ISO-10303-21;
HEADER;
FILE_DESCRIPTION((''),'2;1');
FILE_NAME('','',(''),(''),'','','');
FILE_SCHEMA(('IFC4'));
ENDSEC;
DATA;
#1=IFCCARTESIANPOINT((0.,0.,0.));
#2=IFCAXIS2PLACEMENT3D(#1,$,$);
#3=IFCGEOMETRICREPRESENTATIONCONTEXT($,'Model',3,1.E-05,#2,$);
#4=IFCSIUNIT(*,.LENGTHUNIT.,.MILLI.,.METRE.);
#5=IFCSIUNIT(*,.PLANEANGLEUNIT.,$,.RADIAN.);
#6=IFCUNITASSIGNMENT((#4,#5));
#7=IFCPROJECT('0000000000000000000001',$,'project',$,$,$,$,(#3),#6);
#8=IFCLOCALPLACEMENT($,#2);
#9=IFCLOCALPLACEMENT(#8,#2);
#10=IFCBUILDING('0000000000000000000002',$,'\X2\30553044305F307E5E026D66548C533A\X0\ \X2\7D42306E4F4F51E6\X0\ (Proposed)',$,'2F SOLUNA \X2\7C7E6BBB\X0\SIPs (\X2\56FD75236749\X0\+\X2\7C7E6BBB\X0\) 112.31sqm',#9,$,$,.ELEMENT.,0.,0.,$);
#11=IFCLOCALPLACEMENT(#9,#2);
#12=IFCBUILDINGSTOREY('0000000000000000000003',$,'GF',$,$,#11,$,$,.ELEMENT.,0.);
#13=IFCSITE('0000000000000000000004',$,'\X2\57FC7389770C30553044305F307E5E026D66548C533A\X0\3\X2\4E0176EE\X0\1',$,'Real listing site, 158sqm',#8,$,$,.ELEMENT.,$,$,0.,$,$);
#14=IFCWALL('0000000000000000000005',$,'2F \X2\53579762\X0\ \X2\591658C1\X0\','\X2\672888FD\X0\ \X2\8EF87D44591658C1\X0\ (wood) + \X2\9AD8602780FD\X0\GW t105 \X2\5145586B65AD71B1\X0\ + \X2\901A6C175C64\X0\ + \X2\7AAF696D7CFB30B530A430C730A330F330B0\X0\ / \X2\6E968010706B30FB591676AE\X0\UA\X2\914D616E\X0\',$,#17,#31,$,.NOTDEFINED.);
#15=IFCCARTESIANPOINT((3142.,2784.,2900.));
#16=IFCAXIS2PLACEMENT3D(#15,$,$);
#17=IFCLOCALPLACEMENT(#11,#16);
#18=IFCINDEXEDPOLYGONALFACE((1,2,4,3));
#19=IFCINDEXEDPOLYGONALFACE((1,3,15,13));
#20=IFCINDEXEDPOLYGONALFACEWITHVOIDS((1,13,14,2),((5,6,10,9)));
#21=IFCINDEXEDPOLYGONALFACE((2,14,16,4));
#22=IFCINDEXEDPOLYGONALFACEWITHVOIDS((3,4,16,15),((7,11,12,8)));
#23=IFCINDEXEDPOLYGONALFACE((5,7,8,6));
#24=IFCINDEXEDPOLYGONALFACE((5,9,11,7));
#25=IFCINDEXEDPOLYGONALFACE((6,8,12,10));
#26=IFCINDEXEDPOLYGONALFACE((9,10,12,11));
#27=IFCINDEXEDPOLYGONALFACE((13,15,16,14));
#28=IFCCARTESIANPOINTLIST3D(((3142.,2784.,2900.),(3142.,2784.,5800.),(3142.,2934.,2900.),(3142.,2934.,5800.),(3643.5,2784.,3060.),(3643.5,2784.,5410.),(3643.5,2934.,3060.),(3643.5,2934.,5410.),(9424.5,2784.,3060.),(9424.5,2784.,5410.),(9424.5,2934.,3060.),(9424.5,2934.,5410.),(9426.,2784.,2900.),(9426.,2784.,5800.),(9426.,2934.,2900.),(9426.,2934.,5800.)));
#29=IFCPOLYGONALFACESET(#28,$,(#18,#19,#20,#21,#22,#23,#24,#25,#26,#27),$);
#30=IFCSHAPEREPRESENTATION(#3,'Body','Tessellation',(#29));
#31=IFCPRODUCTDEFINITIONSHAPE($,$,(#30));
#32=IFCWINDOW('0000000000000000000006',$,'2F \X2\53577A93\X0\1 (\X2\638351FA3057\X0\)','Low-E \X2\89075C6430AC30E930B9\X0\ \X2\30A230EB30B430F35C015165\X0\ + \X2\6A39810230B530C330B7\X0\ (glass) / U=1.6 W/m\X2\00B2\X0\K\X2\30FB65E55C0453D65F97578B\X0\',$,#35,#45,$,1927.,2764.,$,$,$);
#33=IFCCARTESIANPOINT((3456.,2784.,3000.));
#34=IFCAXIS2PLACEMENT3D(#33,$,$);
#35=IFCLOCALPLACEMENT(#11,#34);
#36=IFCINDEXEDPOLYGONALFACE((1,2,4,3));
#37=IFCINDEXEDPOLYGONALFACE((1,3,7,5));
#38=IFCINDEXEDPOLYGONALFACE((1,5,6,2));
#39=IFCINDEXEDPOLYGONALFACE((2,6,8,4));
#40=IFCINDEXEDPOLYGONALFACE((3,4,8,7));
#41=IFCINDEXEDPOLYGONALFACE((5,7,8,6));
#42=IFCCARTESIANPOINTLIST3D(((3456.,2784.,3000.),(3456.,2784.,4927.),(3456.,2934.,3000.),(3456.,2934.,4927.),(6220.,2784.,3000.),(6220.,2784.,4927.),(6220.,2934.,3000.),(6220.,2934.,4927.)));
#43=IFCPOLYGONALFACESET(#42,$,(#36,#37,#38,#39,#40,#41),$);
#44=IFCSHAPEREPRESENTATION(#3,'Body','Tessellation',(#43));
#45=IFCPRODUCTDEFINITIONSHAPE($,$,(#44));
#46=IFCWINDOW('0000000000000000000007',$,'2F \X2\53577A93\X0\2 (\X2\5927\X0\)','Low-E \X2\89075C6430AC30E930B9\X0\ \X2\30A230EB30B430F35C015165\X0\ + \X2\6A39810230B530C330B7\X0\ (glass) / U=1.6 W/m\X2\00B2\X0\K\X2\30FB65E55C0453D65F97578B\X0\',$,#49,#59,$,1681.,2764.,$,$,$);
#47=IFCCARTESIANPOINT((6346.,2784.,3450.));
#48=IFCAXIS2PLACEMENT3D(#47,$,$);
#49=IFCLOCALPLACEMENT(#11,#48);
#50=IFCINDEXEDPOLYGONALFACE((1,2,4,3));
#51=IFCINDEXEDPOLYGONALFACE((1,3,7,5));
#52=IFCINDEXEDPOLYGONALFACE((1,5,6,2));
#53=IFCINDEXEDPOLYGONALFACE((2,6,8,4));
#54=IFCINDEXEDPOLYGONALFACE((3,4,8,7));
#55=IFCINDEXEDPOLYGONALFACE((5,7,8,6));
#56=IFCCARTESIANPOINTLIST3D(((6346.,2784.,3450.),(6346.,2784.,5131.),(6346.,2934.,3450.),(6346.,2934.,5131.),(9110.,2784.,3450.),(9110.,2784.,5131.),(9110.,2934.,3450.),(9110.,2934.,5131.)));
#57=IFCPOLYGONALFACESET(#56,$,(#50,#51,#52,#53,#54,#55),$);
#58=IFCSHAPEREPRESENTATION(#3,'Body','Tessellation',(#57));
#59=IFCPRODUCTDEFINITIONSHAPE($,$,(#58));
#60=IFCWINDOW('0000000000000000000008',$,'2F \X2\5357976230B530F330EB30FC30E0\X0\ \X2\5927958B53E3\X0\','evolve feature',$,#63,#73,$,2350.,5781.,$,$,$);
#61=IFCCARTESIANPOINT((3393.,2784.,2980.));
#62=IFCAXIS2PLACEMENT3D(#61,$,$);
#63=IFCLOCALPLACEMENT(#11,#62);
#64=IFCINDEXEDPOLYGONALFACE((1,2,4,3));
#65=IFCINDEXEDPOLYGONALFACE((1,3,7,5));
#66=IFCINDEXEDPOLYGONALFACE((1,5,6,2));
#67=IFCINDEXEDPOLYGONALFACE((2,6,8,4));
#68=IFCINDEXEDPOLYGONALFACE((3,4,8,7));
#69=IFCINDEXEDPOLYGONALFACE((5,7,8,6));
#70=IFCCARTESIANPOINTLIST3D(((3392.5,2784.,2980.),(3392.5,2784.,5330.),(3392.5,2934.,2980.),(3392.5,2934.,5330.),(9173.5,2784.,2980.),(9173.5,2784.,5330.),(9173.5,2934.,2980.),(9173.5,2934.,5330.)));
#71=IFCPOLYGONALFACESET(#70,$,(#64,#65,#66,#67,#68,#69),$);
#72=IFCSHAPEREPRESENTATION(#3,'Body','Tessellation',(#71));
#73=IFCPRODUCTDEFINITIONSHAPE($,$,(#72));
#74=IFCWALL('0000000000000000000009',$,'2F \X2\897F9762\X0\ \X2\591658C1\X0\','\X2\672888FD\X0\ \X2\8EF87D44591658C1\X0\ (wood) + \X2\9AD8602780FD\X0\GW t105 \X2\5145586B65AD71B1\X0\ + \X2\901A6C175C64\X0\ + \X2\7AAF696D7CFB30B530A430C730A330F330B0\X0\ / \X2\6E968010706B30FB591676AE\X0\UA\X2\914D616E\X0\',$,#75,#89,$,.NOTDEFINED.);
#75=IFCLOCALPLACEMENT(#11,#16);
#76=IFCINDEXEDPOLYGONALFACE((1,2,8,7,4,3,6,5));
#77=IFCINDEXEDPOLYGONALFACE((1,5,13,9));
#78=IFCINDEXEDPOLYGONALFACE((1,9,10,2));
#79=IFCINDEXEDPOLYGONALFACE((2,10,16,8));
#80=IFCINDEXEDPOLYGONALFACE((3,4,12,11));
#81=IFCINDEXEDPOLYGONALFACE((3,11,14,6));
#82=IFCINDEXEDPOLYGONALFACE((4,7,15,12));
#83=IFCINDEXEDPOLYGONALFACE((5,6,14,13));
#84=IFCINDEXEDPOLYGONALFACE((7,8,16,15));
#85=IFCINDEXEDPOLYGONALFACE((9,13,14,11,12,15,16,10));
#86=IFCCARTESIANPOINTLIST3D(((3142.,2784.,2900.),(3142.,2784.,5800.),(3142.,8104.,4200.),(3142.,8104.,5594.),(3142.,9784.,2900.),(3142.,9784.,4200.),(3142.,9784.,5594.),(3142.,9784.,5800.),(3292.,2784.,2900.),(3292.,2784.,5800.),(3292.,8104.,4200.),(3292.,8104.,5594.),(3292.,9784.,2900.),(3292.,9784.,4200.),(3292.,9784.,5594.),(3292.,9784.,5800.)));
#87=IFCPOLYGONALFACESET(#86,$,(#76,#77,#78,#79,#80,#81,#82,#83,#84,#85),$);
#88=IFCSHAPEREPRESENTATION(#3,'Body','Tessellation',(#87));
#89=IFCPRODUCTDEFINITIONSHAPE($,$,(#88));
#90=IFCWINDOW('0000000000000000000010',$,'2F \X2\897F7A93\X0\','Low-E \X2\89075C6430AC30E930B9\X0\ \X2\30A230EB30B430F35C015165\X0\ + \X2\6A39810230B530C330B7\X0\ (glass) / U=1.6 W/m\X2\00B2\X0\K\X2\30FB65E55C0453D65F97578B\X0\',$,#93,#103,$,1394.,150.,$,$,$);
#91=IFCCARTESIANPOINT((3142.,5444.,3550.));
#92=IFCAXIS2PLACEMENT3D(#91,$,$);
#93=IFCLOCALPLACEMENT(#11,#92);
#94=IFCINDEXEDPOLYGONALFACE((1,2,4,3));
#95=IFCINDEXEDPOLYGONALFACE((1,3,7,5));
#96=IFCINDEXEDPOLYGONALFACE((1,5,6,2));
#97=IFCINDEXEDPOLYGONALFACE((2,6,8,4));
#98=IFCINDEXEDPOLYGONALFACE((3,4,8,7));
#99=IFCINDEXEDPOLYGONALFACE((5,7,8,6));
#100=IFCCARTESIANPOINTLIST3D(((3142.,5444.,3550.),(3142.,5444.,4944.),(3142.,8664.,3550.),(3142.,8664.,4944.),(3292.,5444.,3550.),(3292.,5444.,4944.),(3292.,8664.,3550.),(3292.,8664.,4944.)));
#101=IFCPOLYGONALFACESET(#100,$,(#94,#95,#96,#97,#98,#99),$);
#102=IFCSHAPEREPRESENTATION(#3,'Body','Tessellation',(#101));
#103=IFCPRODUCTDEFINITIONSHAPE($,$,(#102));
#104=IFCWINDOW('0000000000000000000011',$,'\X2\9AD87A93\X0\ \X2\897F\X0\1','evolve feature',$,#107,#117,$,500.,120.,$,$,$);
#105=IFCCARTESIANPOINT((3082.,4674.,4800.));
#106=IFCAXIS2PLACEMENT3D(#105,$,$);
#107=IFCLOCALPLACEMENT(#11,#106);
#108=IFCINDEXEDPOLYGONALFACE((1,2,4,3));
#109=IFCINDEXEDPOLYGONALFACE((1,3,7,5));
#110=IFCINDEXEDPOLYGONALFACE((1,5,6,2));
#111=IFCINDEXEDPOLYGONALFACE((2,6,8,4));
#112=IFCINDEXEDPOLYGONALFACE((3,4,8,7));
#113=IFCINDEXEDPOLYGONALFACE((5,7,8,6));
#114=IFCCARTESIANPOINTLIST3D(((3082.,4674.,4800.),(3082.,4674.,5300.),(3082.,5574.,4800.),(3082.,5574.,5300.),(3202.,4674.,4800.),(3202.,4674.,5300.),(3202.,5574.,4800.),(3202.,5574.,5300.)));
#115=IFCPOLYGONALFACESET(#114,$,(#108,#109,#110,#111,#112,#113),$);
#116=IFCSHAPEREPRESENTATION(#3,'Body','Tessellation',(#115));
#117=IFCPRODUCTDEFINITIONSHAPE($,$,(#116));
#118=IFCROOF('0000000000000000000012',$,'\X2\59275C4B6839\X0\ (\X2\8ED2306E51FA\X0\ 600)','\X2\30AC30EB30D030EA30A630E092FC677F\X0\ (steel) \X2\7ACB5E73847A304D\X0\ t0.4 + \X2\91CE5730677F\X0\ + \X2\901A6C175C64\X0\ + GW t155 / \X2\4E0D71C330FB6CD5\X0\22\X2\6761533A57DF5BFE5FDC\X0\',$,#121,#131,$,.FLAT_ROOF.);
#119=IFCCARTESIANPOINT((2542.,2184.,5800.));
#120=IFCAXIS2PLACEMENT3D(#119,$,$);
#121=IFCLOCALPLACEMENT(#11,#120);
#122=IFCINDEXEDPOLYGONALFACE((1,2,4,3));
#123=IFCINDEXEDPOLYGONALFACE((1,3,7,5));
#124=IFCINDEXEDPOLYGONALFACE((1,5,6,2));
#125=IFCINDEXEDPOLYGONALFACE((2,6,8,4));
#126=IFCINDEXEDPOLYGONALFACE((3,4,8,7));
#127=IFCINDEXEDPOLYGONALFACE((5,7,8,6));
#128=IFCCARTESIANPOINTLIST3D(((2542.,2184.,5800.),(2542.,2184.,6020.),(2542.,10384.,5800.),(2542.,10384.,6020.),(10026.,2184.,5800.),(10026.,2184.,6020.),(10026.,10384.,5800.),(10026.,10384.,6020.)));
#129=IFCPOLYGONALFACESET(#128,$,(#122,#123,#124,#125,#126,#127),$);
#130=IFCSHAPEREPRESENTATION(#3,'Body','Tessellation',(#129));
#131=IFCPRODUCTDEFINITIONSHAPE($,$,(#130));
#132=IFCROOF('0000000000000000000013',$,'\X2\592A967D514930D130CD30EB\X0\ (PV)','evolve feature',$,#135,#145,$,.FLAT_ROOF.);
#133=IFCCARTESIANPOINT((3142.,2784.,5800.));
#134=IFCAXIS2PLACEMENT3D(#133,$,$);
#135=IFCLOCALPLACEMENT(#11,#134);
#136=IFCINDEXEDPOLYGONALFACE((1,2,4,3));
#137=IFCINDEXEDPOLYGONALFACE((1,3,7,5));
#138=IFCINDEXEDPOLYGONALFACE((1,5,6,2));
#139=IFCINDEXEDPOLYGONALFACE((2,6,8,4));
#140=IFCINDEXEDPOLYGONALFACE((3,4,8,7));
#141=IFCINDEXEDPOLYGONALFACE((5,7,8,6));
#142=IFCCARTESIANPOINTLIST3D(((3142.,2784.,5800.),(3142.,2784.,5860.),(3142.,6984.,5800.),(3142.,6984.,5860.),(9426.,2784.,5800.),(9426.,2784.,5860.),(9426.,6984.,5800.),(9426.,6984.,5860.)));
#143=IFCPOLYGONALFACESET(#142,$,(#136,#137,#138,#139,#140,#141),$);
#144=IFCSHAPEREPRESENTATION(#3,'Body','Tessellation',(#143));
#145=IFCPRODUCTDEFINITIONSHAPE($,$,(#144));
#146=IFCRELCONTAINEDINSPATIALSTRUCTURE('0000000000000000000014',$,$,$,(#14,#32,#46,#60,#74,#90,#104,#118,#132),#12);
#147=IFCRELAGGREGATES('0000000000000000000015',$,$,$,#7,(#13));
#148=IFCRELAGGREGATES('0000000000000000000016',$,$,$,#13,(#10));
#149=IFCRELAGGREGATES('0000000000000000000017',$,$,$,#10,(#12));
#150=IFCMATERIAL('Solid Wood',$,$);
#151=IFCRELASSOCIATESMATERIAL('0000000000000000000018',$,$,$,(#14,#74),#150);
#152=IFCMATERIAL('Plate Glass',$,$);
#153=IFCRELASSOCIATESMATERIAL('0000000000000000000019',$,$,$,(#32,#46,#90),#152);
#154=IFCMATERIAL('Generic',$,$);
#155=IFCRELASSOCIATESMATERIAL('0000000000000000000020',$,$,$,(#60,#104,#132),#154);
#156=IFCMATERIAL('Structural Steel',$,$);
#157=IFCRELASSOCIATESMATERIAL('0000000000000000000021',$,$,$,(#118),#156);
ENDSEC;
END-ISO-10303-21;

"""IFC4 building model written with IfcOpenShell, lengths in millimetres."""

from ifc_helpers import new_model, si_unit, frame, frame_2d, origin, place, context, project, spatial, rectangle, extrude, material, element, fill, save


model = new_model("IFC4")

# Units and contexts
model_context = context("Model", 3, precision=1e-05, world=origin())
ifc_project = project(units=[si_unit("LENGTHUNIT", "METRE", prefix="MILLI"), si_unit("PLANEANGLEUNIT", "RADIAN")], contexts=[model_context])

# Site, building, storey
site_placement = place(None, origin())
site = spatial("IfcSite", under=ifc_project, at=site_placement, Name="埼玉県さいたま市浦和区3丁目1", ObjectType="Real listing site, 158sqm", CompositionType="ELEMENT", RefElevation=0.0)
building_placement = place(site_placement, origin())
building = spatial("IfcBuilding", under=site, at=building_placement, Name="さいたま市浦和区 終の住処 (Proposed)", ObjectType="2F SOLUNA 籾殻SIPs (国産杉+籾殻) 112.31sqm", CompositionType="ELEMENT", ElevationOfRefHeight=0.0, ElevationOfTerrain=0.0)
storey_placement = place(building_placement, origin())
storey = spatial("IfcBuildingStorey", under=building, at=storey_placement, Name="GF", CompositionType="ELEMENT", Elevation=0.0)

# Shared definitions
ifc_material_1 = material(Name="Solid Wood")
ifc_material_2 = material(Name="Generic")

# Shared definitions
ifc_material_3 = material(Name="Plate Glass")

# Walls, openings, windows
wall_1_placement = place(storey_placement, frame((3142.0, 2784.0, 2900.0)))
wall_1 = element("IfcWall", 1, at=wall_1_placement, inside=storey, material=ifc_material_1, Name="2F 南面 外壁", Description="木製 軸組外壁 (wood) + 高性能GW t105 充填断熱 + 通気層 + 窯業系サイディング / 準耐火・外皮UA配慮", PredefinedType="NOTDEFINED", context=model_context, shape_type="SweptSolid", body=[
    extrude(rectangle(XDim=6284.0, YDim=150.0, at=frame_2d((3142.0, 75.0))), frame((3142.0, 2784.0, 2900.0)), (0.0, 0.0, 1.0), 2900.0),
])
opening_1_placement = place(storey_placement, frame((3456.0, 2784.0, 3000.0)))
opening_1 = element("IfcOpeningElement", 2, at=opening_1_placement, cuts=wall_1, PredefinedType="NOTDEFINED", context=model_context, shape_type="SweptSolid", body=[
    extrude(rectangle(XDim=2764.0, YDim=150.0, at=frame_2d((1382.0, 75.0))), frame((3456.0, 2784.0, 3000.0)), (0.0, 0.0, 1.0), 1927.0),
])
opening_2_placement = place(storey_placement, frame((6346.0, 2784.0, 3450.0)))
opening_2 = element("IfcOpeningElement", 3, at=opening_2_placement, cuts=wall_1, PredefinedType="NOTDEFINED", context=model_context, shape_type="SweptSolid", body=[
    extrude(rectangle(XDim=2764.0, YDim=150.0, at=frame_2d((1382.0, 75.0))), frame((6346.0, 2784.0, 3450.0)), (0.0, 0.0, 1.0), 1681.0),
])
opening_3_placement = place(storey_placement, frame((3393.0, 2784.0, 2980.0)))
opening_3 = element("IfcOpeningElement", 4, at=opening_3_placement, cuts=wall_1, PredefinedType="NOTDEFINED", context=model_context, shape_type="SweptSolid", body=[
    extrude(rectangle(XDim=5781.0, YDim=150.0, at=frame_2d((2890.0, 75.0))), frame((3393.0, 2784.0, 2980.0)), (0.0, 0.0, 1.0), 2350.0),
])
window_1_placement = place(storey_placement, frame((3456.0, 2784.0, 3000.0)))
window_1 = element("IfcWindow", 5, at=window_1_placement, inside=storey, material=ifc_material_3, Name="2F 南窓1 (掃出し)", Description="Low-E 複層ガラス アルゴン封入 + 樹脂サッシ (glass) / U=1.6 W/m²K・日射取得型", OverallHeight=1927.0, OverallWidth=2764.0, context=model_context, shape_type="SweptSolid", body=[
    extrude(rectangle(XDim=2764.0, YDim=150.0, at=frame_2d((1382.0, 75.0))), frame((3456.0, 2784.0, 3000.0)), (0.0, 0.0, 1.0), 1927.0),
])
fill(opening_1, window_1)
window_2_placement = place(storey_placement, frame((6346.0, 2784.0, 3450.0)))
window_2 = element("IfcWindow", 6, at=window_2_placement, inside=storey, material=ifc_material_3, Name="2F 南窓2 (大)", Description="Low-E 複層ガラス アルゴン封入 + 樹脂サッシ (glass) / U=1.6 W/m²K・日射取得型", OverallHeight=1681.0, OverallWidth=2764.0, context=model_context, shape_type="SweptSolid", body=[
    extrude(rectangle(XDim=2764.0, YDim=150.0, at=frame_2d((1382.0, 75.0))), frame((6346.0, 2784.0, 3450.0)), (0.0, 0.0, 1.0), 1681.0),
])
fill(opening_2, window_2)
window_3_placement = place(storey_placement, frame((3393.0, 2784.0, 2980.0)))
window_3 = element("IfcWindow", 7, at=window_3_placement, inside=storey, material=ifc_material_2, Name="2F 南面サンルーム 大開口", Description="evolve feature", OverallHeight=2350.0, OverallWidth=5781.0, context=model_context, shape_type="SweptSolid", body=[
    extrude(rectangle(XDim=5781.0, YDim=150.0, at=frame_2d((2890.0, 75.0))), frame((3393.0, 2784.0, 2980.0)), (0.0, 0.0, 1.0), 2350.0),
])
fill(opening_3, window_3)
wall_2_placement = place(storey_placement, frame((3142.0, 2784.0, 2900.0)))
wall_2 = element("IfcWall", 8, at=wall_2_placement, inside=storey, material=ifc_material_1, Name="2F 西面 外壁", Description="木製 軸組外壁 (wood) + 高性能GW t105 充填断熱 + 通気層 + 窯業系サイディング / 準耐火・外皮UA配慮", PredefinedType="NOTDEFINED", context=model_context, shape_type="SweptSolid", body=[
    extrude(rectangle(XDim=150.0, YDim=7000.0, at=frame_2d((75.0, 3500.0))), frame((3142.0, 2784.0, 2900.0)), (0.0, 0.0, 1.0), 2900.0),
])
opening_4_placement = place(storey_placement, frame((3142.0, 5444.0, 3550.0)))
opening_4 = element("IfcOpeningElement", 9, at=opening_4_placement, cuts=wall_2, PredefinedType="NOTDEFINED", context=model_context, shape_type="SweptSolid", body=[
    extrude(rectangle(XDim=150.0, YDim=3220.0, at=frame_2d((75.0, 1610.0))), frame((3142.0, 5444.0, 3550.0)), (0.0, 0.0, 1.0), 1394.0),
])
opening_5_placement = place(storey_placement, frame((3082.0, 4674.0, 4800.0)))
opening_5 = element("IfcOpeningElement", 10, at=opening_5_placement, cuts=wall_2, PredefinedType="NOTDEFINED", context=model_context, shape_type="SweptSolid", body=[
    extrude(rectangle(XDim=120.0, YDim=900.0, at=frame_2d((60.0, 450.0))), frame((3082.0, 4674.0, 4800.0)), (0.0, 0.0, 1.0), 500.0),
])
window_4_placement = place(storey_placement, frame((3142.0, 5444.0, 3550.0)))
window_4 = element("IfcWindow", 11, at=window_4_placement, inside=storey, material=ifc_material_3, Name="2F 西窓", Description="Low-E 複層ガラス アルゴン封入 + 樹脂サッシ (glass) / U=1.6 W/m²K・日射取得型", OverallHeight=1394.0, OverallWidth=150.0, context=model_context, shape_type="SweptSolid", body=[
    extrude(rectangle(XDim=150.0, YDim=3220.0, at=frame_2d((75.0, 1610.0))), frame((3142.0, 5444.0, 3550.0)), (0.0, 0.0, 1.0), 1394.0),
])
fill(opening_4, window_4)
window_5_placement = place(storey_placement, frame((3082.0, 4674.0, 4800.0)))
window_5 = element("IfcWindow", 12, at=window_5_placement, inside=storey, material=ifc_material_2, Name="高窓 西1", Description="evolve feature", OverallHeight=500.0, OverallWidth=120.0, context=model_context, shape_type="SweptSolid", body=[
    extrude(rectangle(XDim=120.0, YDim=900.0, at=frame_2d((60.0, 450.0))), frame((3082.0, 4674.0, 4800.0)), (0.0, 0.0, 1.0), 500.0),
])
fill(opening_5, window_5)

# Roofs
ifc_material_4 = material(Name="Structural Steel")
roof_1_placement = place(storey_placement, frame((2542.0, 2184.0, 5800.0)))
element("IfcRoof", 13, at=roof_1_placement, inside=storey, material=ifc_material_4, Name="大屋根 (軒の出 600)", Description="ガルバリウム鋼板 (steel) 立平葺き t0.4 + 野地板 + 通気層 + GW t155 / 不燃・法22条区域対応", PredefinedType="FLAT_ROOF", context=model_context, shape_type="SweptSolid", body=[
    extrude(rectangle(XDim=7484.0, YDim=8200.0, at=frame_2d((3742.0, 4100.0))), frame((2542.0, 2184.0, 5800.0)), (0.0, 0.0, 1.0), 220.0),
])
roof_2_placement = place(storey_placement, frame((3142.0, 2784.0, 5800.0)))
element("IfcRoof", 14, at=roof_2_placement, inside=storey, material=ifc_material_2, Name="太陽光パネル (PV)", Description="evolve feature", PredefinedType="FLAT_ROOF", context=model_context, shape_type="SweptSolid", body=[
    extrude(rectangle(XDim=6284.0, YDim=4200.0, at=frame_2d((3142.0, 2100.0))), frame((3142.0, 2784.0, 5800.0)), (0.0, 0.0, 1.0), 60.0),
])

save(model, "model.ifc")
